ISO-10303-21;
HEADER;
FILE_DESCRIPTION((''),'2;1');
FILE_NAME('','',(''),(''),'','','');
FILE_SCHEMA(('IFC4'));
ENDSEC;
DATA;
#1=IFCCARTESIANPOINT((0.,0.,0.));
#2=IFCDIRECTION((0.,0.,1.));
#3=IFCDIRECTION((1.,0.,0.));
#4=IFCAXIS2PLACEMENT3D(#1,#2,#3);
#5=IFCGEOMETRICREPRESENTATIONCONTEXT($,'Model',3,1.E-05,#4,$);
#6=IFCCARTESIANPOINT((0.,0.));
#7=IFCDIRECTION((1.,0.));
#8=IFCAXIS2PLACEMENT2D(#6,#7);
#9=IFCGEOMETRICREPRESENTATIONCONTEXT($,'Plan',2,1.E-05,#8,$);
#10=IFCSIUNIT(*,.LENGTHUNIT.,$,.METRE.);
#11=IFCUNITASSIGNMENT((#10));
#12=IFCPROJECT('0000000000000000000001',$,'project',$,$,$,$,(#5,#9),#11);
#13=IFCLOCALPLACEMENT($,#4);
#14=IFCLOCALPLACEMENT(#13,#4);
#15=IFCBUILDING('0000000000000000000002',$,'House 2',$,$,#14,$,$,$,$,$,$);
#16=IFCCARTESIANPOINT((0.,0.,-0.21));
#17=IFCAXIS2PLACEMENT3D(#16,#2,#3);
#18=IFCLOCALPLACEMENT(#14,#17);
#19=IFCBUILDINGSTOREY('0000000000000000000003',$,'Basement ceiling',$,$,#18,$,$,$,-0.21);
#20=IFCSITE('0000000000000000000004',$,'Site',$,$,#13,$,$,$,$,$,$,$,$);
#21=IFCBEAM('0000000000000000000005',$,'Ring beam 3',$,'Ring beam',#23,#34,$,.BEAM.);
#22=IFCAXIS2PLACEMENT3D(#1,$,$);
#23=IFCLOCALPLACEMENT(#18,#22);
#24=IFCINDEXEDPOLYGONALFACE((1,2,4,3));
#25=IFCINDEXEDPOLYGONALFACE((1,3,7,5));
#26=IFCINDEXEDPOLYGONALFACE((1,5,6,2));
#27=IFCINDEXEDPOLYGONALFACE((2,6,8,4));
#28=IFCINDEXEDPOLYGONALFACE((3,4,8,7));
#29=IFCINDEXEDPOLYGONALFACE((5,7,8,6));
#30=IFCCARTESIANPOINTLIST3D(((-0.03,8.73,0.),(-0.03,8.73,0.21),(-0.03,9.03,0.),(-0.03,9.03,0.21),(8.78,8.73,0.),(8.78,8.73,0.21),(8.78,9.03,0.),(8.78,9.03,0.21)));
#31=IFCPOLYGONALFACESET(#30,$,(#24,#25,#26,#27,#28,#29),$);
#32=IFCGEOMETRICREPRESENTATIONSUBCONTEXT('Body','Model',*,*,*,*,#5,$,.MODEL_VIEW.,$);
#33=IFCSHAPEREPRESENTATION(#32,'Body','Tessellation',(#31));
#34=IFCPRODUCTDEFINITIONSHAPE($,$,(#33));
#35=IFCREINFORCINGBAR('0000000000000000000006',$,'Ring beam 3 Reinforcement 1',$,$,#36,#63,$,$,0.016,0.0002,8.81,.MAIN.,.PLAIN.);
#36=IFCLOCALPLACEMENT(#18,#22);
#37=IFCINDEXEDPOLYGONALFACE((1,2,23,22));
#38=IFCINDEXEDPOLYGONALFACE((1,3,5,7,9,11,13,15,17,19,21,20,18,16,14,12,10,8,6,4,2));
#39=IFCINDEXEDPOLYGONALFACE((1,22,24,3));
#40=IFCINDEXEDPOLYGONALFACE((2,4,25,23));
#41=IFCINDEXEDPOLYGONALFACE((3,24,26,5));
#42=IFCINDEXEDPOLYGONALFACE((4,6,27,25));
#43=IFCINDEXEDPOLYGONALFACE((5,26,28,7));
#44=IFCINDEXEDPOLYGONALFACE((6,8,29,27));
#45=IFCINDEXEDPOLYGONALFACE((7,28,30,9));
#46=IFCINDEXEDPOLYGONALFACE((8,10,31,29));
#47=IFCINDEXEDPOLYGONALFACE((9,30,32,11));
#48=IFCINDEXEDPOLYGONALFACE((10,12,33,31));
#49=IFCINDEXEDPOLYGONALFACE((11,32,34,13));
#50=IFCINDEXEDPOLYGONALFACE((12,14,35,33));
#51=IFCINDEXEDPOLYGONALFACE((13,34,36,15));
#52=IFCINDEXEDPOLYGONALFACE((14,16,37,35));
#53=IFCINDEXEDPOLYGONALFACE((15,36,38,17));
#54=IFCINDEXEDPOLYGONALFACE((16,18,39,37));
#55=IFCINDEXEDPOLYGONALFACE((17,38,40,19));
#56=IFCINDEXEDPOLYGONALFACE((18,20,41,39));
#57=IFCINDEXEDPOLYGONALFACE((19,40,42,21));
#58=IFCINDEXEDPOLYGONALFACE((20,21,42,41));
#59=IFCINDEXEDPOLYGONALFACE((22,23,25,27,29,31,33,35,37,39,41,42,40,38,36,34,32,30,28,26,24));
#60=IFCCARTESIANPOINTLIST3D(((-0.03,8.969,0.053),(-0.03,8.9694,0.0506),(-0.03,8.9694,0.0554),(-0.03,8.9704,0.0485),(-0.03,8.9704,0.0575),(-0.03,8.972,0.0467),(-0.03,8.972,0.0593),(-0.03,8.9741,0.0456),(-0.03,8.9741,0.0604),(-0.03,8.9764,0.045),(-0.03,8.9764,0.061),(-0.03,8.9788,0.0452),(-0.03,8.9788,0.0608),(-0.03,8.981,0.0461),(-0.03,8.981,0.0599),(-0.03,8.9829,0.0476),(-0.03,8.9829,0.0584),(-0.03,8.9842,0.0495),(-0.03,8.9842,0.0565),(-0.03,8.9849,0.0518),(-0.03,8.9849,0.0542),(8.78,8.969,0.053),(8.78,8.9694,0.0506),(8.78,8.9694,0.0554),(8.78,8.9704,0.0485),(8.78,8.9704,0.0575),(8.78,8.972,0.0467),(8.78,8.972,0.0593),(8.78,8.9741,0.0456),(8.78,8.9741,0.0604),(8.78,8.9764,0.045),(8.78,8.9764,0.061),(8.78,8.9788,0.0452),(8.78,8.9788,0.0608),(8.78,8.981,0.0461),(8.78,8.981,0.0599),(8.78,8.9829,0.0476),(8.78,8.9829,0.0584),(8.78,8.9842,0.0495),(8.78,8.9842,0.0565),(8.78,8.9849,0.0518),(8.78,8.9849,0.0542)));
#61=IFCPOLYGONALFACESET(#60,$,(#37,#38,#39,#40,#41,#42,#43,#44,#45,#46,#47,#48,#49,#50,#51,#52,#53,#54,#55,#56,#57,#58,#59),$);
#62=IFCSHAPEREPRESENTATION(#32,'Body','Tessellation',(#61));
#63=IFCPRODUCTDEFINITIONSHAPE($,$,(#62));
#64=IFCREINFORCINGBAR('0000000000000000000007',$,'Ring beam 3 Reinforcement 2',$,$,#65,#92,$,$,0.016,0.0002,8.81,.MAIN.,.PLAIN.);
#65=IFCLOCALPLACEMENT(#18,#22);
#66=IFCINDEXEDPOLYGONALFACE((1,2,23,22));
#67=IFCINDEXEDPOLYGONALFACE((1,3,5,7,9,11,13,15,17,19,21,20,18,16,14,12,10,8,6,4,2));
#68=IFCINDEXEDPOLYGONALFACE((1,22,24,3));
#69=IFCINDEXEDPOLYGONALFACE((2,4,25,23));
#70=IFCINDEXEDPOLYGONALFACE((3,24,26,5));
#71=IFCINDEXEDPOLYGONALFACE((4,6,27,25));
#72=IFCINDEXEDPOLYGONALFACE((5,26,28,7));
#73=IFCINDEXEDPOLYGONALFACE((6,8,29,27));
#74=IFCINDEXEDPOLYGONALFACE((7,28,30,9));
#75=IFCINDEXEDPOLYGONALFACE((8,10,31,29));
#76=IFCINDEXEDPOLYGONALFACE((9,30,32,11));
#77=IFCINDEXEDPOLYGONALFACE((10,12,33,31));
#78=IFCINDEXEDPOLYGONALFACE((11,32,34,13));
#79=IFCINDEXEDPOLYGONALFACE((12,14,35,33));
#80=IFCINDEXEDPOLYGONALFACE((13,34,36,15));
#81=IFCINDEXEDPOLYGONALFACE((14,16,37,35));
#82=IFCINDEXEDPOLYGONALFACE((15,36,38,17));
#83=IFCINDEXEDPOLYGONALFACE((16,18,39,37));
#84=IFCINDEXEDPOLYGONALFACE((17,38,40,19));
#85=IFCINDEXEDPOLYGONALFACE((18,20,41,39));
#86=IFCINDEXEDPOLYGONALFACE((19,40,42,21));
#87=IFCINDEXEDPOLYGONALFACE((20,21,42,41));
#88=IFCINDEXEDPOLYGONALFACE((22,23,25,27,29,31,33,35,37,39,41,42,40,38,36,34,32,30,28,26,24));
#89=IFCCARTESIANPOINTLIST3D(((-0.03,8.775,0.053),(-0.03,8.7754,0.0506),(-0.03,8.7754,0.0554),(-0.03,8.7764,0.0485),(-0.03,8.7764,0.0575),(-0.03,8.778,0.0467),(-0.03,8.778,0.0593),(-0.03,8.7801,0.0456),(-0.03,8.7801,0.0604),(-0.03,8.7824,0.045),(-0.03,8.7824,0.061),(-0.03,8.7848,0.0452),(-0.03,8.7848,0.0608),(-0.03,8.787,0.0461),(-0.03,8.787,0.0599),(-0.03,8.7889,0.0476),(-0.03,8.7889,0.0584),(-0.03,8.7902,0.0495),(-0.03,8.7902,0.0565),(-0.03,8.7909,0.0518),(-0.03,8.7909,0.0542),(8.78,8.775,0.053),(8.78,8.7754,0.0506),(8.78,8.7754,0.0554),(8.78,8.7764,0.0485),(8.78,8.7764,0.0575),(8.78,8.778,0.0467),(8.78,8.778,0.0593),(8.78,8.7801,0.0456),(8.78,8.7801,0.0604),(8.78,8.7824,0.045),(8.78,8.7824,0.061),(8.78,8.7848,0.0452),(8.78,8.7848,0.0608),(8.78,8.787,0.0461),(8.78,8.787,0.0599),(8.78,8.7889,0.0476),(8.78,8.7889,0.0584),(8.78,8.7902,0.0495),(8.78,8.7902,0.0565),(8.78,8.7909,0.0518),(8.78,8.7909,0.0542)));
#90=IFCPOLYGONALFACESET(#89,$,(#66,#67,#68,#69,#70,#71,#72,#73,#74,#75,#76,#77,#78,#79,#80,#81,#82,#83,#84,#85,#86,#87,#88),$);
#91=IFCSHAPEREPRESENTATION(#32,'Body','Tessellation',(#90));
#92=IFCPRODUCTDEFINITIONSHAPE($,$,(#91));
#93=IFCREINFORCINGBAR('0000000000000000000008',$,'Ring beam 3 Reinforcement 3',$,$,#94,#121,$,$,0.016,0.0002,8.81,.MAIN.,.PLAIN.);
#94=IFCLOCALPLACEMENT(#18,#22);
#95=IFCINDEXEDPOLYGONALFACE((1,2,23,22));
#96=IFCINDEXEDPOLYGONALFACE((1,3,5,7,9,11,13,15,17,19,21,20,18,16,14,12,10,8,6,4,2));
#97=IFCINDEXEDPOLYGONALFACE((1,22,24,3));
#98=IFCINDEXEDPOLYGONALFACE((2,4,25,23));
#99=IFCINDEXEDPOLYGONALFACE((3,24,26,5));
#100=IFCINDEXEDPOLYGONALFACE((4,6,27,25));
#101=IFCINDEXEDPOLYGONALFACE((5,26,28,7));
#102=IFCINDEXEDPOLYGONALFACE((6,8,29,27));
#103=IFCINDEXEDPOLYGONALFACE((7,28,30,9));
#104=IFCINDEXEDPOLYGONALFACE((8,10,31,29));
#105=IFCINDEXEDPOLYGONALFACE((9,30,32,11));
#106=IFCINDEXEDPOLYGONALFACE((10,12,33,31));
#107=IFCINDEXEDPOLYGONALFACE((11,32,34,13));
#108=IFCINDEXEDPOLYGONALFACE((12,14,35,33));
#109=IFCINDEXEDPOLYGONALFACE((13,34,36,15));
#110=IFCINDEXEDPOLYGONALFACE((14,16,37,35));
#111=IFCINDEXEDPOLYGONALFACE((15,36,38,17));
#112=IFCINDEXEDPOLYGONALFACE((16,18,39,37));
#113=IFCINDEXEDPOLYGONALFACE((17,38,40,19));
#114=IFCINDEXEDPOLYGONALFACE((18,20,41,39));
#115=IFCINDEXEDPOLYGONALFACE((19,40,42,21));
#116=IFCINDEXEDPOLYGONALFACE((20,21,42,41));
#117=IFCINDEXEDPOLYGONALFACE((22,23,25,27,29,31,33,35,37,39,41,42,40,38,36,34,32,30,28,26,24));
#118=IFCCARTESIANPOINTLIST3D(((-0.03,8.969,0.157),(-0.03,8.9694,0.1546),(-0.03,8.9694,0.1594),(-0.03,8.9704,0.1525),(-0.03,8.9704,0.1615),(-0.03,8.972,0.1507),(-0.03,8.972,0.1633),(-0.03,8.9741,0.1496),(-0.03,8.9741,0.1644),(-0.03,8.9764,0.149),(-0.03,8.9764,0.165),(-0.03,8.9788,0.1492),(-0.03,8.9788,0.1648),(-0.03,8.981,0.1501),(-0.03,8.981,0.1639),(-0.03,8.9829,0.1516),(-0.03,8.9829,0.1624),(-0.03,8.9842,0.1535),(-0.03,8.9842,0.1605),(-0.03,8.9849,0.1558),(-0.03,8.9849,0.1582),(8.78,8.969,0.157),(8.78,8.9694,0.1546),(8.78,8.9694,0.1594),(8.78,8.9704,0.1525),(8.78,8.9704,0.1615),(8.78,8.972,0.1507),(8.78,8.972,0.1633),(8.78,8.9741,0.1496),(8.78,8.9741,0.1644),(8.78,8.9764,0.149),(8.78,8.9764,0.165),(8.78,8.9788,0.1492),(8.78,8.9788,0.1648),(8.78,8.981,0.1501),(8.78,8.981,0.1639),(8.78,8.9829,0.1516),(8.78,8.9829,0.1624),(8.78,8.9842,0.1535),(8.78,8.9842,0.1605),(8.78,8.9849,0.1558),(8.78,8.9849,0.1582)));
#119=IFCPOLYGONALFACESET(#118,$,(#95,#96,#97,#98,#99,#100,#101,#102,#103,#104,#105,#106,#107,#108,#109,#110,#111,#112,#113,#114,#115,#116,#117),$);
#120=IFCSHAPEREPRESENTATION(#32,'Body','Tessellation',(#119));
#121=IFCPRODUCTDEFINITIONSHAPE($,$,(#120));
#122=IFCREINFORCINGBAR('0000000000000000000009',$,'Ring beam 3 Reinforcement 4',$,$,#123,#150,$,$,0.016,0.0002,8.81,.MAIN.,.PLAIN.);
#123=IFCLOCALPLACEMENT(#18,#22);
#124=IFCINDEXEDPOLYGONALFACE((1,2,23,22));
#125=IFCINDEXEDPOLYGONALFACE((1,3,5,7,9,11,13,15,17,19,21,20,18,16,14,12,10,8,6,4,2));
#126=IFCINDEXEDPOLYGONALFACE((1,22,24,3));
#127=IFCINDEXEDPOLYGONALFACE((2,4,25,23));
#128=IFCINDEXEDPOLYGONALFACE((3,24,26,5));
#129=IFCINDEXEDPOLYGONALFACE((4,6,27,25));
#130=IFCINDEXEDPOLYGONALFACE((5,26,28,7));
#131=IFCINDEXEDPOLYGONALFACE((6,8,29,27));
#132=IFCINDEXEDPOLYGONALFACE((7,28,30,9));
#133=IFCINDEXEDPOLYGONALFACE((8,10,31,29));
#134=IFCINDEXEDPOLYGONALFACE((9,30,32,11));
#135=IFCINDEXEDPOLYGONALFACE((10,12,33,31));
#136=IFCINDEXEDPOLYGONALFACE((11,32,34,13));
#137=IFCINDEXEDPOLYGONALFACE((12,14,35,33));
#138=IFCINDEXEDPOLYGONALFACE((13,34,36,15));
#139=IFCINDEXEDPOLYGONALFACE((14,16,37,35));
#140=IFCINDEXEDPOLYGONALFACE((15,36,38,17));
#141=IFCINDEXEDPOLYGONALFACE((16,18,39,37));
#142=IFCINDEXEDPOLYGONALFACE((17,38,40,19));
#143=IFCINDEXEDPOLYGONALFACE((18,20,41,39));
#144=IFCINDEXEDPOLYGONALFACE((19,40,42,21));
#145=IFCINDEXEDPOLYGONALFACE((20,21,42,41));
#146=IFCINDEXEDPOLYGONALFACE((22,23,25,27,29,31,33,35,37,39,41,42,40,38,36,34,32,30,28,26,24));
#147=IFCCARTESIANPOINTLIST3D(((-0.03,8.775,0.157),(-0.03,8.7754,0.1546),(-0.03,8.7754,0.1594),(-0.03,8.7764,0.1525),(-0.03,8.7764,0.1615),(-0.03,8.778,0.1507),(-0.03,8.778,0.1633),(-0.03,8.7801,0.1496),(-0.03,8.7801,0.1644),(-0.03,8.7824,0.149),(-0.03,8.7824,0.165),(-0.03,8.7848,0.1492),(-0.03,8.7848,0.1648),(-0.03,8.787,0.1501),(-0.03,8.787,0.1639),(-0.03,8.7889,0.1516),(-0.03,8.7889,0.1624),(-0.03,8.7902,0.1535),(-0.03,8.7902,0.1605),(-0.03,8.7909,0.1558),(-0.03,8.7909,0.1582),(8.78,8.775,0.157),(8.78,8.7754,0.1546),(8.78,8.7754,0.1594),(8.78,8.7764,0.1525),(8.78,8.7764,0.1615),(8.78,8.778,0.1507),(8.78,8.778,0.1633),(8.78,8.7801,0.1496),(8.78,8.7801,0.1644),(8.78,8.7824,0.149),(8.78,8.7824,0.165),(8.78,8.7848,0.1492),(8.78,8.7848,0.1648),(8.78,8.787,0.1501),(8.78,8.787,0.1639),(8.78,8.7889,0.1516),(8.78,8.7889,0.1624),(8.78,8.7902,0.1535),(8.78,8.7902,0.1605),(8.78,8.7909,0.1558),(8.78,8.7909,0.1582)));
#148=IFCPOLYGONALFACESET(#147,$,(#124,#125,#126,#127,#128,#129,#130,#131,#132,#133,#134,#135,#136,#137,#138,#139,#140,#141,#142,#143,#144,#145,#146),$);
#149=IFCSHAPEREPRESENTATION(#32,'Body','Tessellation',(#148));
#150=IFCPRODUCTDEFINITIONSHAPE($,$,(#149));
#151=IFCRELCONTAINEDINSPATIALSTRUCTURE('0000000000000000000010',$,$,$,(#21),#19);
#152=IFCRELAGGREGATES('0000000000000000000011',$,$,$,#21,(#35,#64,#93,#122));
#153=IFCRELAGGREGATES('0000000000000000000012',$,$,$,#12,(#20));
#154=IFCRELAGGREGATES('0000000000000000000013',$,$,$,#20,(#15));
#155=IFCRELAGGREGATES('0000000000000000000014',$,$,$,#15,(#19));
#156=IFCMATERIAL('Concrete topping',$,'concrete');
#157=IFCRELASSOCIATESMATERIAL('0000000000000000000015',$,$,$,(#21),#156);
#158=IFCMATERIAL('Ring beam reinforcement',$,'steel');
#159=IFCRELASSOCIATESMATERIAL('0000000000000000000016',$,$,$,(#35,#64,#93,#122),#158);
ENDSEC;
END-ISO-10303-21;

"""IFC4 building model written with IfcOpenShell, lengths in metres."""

from ifc_helpers import new_model, si_unit, frame, origin_with_axes, origin_2d, origin_2d_with_axis, place, context, subcontext, project, spatial, circle_curve, rectangle, outline, extrude, material, element, aggregate, save


model = new_model("IFC4")

# Units and contexts
model_context = context("Model", 3, precision=1e-05, world=origin_with_axes())
plan_context = context("Plan", 2, precision=1e-05, world=origin_2d_with_axis())
body_context = subcontext(model_context, "Body", "Model", "MODEL_VIEW")
ifc_project = project(units=[si_unit("LENGTHUNIT", "METRE")], contexts=[model_context, plan_context])

# Site, building, storey
site_placement = place(None, origin_with_axes())
site = spatial("IfcSite", under=ifc_project, at=site_placement, Name="Site")
building_placement = place(site_placement, origin_with_axes())
building = spatial("IfcBuilding", under=site, at=building_placement, Name="House 2")
storey_placement = place(building_placement, frame((0.0, 0.0, -0.21), z_axis=(0.0, 0.0, 1.0), x_axis=(1.0, 0.0, 0.0)))
storey = spatial("IfcBuildingStorey", under=building, at=storey_placement, Name="Basement ceiling", Elevation=-0.21)

# Beam
ifc_material_1 = material(Name="Concrete topping", Category="concrete")
beam_1_placement = place(storey_placement, frame((8.78, 8.88, 0.105), z_axis=(0.0, 0.0, 1.0), x_axis=(-1.0, 0.0, 0.0)))
beam_1 = element("IfcBeam", 1, at=beam_1_placement, inside=storey, material=ifc_material_1, Name="Ring beam 3", ObjectType="Ring beam", PredefinedType="BEAM", context=body_context, shape_type="SweptSolid", body=[
    extrude(rectangle(XDim=0.3, YDim=0.21), frame((0.0, 0.0, 0.0), z_axis=(1.0, 0.0, 0.0), x_axis=(0.0, 1.0, 0.0)), (0.0, 0.0, 1.0), 8.81),
])

# Reinforcing bars
ifc_material_2 = material(Name="Ring beam reinforcement", Category="steel")
reinforcing_bar_1_placement = place(beam_1_placement, frame((0.0, -0.097, -0.052), z_axis=(0.0, 0.0, 1.0), x_axis=(1.0, 0.0, 0.0)))
reinforcing_bar_1 = element("IfcReinforcingBar", 2, at=reinforcing_bar_1_placement, material=ifc_material_2, Name="Ring beam 3 Reinforcement 1", BarLength=8.81, BarSurface="PLAIN", CrossSectionArea=0.0002, NominalDiameter=0.016, PredefinedType="MAIN", context=body_context, shape_type="SweptSolid", body=[
    extrude(outline(circle_curve(origin_2d(), 0.008)), frame((0.0, 0.0, 0.0), z_axis=(1.0, 0.0, 0.0), x_axis=(0.0, 1.0, 0.0)), (0.0, 0.0, 1.0), 8.81),
])
reinforcing_bar_2_placement = place(beam_1_placement, frame((0.0, 0.097, -0.052), z_axis=(0.0, 0.0, 1.0), x_axis=(1.0, 0.0, 0.0)))
reinforcing_bar_2 = element("IfcReinforcingBar", 3, at=reinforcing_bar_2_placement, material=ifc_material_2, Name="Ring beam 3 Reinforcement 2", BarLength=8.81, BarSurface="PLAIN", CrossSectionArea=0.0002, NominalDiameter=0.016, PredefinedType="MAIN", context=body_context, shape_type="SweptSolid", body=[
    extrude(outline(circle_curve(origin_2d(), 0.008)), frame((0.0, 0.0, 0.0), z_axis=(1.0, 0.0, 0.0), x_axis=(0.0, 1.0, 0.0)), (0.0, 0.0, 1.0), 8.81),
])
reinforcing_bar_3_placement = place(beam_1_placement, frame((0.0, -0.097, 0.052), z_axis=(0.0, 0.0, 1.0), x_axis=(1.0, 0.0, 0.0)))
reinforcing_bar_3 = element("IfcReinforcingBar", 4, at=reinforcing_bar_3_placement, material=ifc_material_2, Name="Ring beam 3 Reinforcement 3", BarLength=8.81, BarSurface="PLAIN", CrossSectionArea=0.0002, NominalDiameter=0.016, PredefinedType="MAIN", context=body_context, shape_type="SweptSolid", body=[
    extrude(outline(circle_curve(origin_2d(), 0.008)), frame((0.0, 0.0, 0.0), z_axis=(1.0, 0.0, 0.0), x_axis=(0.0, 1.0, 0.0)), (0.0, 0.0, 1.0), 8.81),
])
reinforcing_bar_4_placement = place(beam_1_placement, frame((0.0, 0.097, 0.052), z_axis=(0.0, 0.0, 1.0), x_axis=(1.0, 0.0, 0.0)))
reinforcing_bar_4 = element("IfcReinforcingBar", 5, at=reinforcing_bar_4_placement, material=ifc_material_2, Name="Ring beam 3 Reinforcement 4", BarLength=8.81, BarSurface="PLAIN", CrossSectionArea=0.0002, NominalDiameter=0.016, PredefinedType="MAIN", context=body_context, shape_type="SweptSolid", body=[
    extrude(outline(circle_curve(origin_2d(), 0.008)), frame((0.0, 0.0, 0.0), z_axis=(1.0, 0.0, 0.0), x_axis=(0.0, 1.0, 0.0)), (0.0, 0.0, 1.0), 8.81),
])
aggregate(beam_1, [reinforcing_bar_1, reinforcing_bar_2, reinforcing_bar_3, reinforcing_bar_4])

save(model, "model.ifc")
